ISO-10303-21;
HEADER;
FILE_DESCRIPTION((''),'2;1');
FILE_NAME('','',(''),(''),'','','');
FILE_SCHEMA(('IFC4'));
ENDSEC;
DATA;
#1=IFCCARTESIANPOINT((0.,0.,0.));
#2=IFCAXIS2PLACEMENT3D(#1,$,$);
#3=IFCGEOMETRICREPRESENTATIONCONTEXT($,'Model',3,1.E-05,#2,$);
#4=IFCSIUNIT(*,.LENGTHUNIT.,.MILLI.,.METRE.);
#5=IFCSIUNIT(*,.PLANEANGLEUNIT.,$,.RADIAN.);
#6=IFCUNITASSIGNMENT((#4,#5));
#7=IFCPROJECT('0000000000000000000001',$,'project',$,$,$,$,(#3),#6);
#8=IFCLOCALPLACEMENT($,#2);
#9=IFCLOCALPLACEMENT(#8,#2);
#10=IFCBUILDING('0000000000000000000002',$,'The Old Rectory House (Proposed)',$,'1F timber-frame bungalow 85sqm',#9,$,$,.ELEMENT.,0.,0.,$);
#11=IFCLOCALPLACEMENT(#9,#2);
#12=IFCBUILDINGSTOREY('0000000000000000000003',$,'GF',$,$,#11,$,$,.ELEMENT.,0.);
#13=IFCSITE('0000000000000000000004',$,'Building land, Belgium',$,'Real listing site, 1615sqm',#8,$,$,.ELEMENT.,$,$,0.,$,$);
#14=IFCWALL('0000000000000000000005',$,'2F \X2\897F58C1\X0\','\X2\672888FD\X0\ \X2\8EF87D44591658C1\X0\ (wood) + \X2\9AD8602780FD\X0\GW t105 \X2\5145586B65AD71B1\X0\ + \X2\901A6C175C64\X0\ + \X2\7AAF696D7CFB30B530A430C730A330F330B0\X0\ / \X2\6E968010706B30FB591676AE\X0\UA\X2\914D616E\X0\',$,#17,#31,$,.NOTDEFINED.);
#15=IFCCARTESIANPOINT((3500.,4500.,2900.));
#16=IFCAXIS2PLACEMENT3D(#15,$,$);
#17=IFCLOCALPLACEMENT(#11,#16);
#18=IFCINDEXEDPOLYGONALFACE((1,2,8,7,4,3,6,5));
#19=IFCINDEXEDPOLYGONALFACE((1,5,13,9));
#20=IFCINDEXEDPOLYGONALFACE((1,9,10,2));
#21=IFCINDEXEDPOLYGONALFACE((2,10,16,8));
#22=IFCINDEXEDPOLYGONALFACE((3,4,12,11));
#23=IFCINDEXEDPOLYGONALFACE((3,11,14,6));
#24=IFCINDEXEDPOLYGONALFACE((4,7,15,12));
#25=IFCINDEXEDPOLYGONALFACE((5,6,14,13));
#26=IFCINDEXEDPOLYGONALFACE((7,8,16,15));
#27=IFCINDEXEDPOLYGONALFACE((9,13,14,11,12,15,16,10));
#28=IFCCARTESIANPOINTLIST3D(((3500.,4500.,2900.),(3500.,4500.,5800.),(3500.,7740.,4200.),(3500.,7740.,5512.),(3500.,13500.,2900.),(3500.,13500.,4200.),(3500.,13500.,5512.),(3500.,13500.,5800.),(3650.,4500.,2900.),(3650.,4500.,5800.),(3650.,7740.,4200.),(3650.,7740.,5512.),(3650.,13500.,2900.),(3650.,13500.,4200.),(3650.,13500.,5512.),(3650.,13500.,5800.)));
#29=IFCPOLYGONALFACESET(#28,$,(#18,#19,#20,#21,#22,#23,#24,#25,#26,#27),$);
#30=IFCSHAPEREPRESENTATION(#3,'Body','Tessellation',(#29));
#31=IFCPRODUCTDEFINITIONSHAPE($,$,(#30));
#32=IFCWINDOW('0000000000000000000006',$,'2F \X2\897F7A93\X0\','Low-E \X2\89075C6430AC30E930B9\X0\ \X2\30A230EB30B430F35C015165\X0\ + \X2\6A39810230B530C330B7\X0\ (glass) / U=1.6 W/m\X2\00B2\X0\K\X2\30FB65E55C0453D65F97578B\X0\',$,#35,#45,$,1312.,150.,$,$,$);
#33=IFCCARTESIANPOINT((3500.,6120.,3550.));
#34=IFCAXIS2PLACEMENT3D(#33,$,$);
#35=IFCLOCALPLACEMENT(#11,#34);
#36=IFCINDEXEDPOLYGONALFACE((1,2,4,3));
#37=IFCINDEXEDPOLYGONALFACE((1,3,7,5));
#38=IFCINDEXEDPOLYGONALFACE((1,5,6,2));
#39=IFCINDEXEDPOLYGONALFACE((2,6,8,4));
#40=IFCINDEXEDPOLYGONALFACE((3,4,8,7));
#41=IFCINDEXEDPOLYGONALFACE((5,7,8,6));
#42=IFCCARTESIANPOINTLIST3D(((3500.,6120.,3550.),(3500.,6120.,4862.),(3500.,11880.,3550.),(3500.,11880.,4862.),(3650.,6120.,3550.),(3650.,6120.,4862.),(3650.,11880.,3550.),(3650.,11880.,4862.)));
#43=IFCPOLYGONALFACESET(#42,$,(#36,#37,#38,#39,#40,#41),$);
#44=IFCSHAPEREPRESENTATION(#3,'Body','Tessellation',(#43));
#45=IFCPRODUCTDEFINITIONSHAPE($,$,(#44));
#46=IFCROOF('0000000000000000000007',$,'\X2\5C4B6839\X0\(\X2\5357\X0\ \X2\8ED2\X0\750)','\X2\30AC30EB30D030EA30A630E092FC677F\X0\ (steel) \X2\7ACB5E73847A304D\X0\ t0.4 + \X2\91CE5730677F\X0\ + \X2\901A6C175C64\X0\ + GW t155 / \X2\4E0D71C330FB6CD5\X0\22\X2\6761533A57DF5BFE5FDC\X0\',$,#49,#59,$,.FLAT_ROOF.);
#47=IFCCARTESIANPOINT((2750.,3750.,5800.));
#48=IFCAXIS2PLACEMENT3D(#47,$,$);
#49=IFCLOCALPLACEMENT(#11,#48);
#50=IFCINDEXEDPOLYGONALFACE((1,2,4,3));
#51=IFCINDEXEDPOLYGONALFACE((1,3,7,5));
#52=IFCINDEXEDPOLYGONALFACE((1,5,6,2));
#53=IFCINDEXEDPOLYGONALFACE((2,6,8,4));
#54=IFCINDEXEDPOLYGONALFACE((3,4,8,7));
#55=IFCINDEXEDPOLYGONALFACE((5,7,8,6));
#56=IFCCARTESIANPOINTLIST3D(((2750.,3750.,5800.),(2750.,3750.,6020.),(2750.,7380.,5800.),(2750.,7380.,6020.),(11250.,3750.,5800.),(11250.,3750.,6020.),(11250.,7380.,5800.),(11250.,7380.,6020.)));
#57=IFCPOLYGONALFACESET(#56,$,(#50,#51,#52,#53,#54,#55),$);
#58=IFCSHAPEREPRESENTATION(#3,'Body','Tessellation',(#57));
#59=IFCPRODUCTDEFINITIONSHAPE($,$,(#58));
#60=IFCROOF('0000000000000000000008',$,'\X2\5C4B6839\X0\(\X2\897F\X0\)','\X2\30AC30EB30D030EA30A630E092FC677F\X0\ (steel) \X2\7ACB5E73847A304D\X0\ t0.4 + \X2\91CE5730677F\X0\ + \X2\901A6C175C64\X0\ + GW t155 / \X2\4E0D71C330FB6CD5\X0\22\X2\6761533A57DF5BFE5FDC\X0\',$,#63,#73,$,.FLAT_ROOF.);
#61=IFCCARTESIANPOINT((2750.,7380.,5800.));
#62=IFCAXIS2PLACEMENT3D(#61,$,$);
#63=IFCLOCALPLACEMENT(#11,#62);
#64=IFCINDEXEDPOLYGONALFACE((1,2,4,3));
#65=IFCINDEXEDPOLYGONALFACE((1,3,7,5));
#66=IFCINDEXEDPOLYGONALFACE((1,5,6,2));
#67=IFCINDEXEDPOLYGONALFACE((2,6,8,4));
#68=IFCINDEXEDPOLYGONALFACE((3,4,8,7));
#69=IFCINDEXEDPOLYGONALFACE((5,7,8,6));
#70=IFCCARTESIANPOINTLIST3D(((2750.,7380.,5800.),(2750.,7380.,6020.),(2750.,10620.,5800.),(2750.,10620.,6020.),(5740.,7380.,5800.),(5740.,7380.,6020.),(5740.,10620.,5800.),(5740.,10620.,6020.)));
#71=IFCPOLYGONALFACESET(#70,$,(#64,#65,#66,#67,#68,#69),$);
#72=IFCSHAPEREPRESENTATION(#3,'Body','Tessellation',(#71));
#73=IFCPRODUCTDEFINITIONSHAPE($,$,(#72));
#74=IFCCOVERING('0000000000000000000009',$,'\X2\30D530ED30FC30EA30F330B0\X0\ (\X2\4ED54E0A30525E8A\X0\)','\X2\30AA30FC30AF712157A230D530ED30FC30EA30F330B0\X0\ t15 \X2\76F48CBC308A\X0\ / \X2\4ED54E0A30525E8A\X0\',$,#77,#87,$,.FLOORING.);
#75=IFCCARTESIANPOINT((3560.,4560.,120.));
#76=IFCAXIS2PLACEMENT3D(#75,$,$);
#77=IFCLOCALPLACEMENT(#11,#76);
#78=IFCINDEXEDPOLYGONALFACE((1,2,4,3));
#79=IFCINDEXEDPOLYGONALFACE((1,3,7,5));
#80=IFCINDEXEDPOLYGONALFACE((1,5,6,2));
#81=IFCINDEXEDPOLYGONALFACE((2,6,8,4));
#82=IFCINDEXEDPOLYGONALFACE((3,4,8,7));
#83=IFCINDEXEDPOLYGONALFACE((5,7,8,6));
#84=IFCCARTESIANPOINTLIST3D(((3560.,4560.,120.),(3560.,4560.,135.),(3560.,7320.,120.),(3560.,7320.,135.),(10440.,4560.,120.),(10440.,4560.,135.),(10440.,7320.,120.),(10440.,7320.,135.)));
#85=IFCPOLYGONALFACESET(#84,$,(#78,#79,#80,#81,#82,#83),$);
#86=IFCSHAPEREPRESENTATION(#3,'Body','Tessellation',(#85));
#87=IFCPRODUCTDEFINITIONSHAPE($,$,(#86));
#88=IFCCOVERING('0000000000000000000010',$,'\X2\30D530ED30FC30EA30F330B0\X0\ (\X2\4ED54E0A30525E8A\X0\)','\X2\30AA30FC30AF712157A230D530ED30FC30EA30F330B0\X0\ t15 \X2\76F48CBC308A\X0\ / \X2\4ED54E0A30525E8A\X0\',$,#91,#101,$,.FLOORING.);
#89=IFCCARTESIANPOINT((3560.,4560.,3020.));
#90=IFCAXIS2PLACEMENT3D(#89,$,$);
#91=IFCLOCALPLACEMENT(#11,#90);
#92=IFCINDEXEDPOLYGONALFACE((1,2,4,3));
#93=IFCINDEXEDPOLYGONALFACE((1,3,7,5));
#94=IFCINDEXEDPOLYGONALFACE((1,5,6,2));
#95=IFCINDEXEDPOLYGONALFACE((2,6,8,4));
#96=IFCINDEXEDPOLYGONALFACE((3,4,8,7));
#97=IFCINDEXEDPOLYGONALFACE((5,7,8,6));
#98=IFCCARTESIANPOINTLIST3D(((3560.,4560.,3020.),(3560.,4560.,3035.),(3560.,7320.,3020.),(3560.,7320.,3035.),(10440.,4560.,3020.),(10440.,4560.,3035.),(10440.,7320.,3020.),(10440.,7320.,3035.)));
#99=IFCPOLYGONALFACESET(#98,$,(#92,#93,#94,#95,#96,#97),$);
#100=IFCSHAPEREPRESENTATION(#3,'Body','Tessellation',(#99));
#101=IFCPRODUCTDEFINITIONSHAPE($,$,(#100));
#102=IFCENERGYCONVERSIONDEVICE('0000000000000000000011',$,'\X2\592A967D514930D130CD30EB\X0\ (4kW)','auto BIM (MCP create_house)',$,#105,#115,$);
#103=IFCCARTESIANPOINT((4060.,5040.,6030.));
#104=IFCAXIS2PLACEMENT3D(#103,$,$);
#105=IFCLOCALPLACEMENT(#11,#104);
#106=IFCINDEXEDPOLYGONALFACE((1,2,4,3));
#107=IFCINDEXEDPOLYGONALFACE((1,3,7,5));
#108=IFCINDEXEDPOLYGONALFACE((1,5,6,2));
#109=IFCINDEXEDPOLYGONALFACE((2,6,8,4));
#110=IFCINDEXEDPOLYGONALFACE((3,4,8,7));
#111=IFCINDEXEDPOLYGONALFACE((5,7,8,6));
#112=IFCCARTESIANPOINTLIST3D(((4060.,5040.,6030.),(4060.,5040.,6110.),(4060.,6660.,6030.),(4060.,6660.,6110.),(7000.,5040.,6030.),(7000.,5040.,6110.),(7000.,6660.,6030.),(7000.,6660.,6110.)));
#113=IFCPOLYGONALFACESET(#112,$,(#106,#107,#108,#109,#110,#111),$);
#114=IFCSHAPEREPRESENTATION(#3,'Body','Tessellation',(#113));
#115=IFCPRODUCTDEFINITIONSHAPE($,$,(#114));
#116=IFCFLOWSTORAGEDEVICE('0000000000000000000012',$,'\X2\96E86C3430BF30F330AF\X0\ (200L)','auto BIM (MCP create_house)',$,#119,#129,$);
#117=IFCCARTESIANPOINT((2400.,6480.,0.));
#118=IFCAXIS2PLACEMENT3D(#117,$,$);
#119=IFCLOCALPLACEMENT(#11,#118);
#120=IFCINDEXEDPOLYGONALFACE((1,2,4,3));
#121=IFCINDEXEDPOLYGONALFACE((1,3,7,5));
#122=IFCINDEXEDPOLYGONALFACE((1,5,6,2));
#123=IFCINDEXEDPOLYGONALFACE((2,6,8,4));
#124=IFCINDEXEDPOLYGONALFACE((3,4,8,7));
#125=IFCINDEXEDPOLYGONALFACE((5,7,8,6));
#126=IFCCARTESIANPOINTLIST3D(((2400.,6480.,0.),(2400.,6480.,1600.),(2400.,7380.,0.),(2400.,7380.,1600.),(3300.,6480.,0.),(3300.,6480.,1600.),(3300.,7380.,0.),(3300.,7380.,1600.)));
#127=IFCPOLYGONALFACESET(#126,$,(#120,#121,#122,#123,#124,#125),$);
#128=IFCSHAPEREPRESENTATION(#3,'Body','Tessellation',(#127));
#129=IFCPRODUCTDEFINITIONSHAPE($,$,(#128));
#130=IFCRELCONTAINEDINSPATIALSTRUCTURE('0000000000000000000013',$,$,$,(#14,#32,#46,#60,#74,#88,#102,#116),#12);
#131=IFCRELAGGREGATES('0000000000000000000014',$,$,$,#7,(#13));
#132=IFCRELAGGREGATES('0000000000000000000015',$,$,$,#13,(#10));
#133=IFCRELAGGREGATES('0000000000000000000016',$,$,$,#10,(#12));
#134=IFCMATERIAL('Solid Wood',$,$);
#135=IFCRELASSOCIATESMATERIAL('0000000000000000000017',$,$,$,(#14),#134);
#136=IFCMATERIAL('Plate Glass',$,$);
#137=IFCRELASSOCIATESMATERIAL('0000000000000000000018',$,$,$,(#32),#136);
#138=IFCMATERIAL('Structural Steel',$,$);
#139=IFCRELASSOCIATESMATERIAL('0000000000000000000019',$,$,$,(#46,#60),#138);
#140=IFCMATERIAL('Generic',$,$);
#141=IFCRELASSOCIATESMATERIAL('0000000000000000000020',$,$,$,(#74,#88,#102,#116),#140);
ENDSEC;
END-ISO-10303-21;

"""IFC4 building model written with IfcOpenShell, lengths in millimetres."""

from ifc_helpers import new_model, si_unit, frame, frame_2d, origin, place, context, project, spatial, rectangle, extrude, material, element, fill, save


model = new_model("IFC4")

# Units and contexts
model_context = context("Model", 3, precision=1e-05, world=origin())
ifc_project = project(units=[si_unit("LENGTHUNIT", "METRE", prefix="MILLI"), si_unit("PLANEANGLEUNIT", "RADIAN")], contexts=[model_context])

# Site, building, storey
site_placement = place(None, origin())
site = spatial("IfcSite", under=ifc_project, at=site_placement, Name="Building land, Belgium", ObjectType="Real listing site, 1615sqm", CompositionType="ELEMENT", RefElevation=0.0)
building_placement = place(site_placement, origin())
building = spatial("IfcBuilding", under=site, at=building_placement, Name="The Old Rectory House (Proposed)", ObjectType="1F timber-frame bungalow 85sqm", CompositionType="ELEMENT", ElevationOfRefHeight=0.0, ElevationOfTerrain=0.0)
storey_placement = place(building_placement, origin())
storey = spatial("IfcBuildingStorey", under=building, at=storey_placement, Name="GF", CompositionType="ELEMENT", Elevation=0.0)

# Shared definitions
ifc_material_1 = material(Name="Solid Wood")
ifc_material_2 = material(Name="Generic")

# Shared definitions
ifc_material_3 = material(Name="Plate Glass")

# Wall, opening, window
wall_1_placement = place(storey_placement, frame((3500.0, 4500.0, 2900.0)))
wall_1 = element("IfcWall", 1, at=wall_1_placement, inside=storey, material=ifc_material_1, Name="2F 西壁", Description="木製 軸組外壁 (wood) + 高性能GW t105 充填断熱 + 通気層 + 窯業系サイディング / 準耐火・外皮UA配慮", PredefinedType="NOTDEFINED", context=model_context, shape_type="SweptSolid", body=[
    extrude(rectangle(XDim=150.0, YDim=9000.0, at=frame_2d((75.0, 4500.0))), frame((3500.0, 4500.0, 2900.0)), (0.0, 0.0, 1.0), 2900.0),
])
opening_1_placement = place(storey_placement, frame((3500.0, 6120.0, 3550.0)))
opening_1 = element("IfcOpeningElement", 2, at=opening_1_placement, cuts=wall_1, PredefinedType="NOTDEFINED", context=model_context, shape_type="SweptSolid", body=[
    extrude(rectangle(XDim=150.0, YDim=5760.0, at=frame_2d((75.0, 2880.0))), frame((3500.0, 6120.0, 3550.0)), (0.0, 0.0, 1.0), 1312.0),
])
window_1_placement = place(storey_placement, frame((3500.0, 6120.0, 3550.0)))
window_1 = element("IfcWindow", 3, at=window_1_placement, inside=storey, material=ifc_material_3, Name="2F 西窓", Description="Low-E 複層ガラス アルゴン封入 + 樹脂サッシ (glass) / U=1.6 W/m²K・日射取得型", OverallHeight=1312.0, OverallWidth=150.0, context=model_context, shape_type="SweptSolid", body=[
    extrude(rectangle(XDim=150.0, YDim=5760.0, at=frame_2d((75.0, 2880.0))), frame((3500.0, 6120.0, 3550.0)), (0.0, 0.0, 1.0), 1312.0),
])
fill(opening_1, window_1)

# Roofs
ifc_material_4 = material(Name="Structural Steel")
roof_1_placement = place(storey_placement, frame((2750.0, 3750.0, 5800.0)))
element("IfcRoof", 4, at=roof_1_placement, inside=storey, material=ifc_material_4, Name="屋根(南 軒750)", Description="ガルバリウム鋼板 (steel) 立平葺き t0.4 + 野地板 + 通気層 + GW t155 / 不燃・法22条区域対応", PredefinedType="FLAT_ROOF", context=model_context, shape_type="SweptSolid", body=[
    extrude(rectangle(XDim=8500.0, YDim=3630.0, at=frame_2d((4250.0, 1815.0))), frame((2750.0, 3750.0, 5800.0)), (0.0, 0.0, 1.0), 220.0),
])
roof_2_placement = place(storey_placement, frame((2750.0, 7380.0, 5800.0)))
element("IfcRoof", 5, at=roof_2_placement, inside=storey, material=ifc_material_4, Name="屋根(西)", Description="ガルバリウム鋼板 (steel) 立平葺き t0.4 + 野地板 + 通気層 + GW t155 / 不燃・法22条区域対応", PredefinedType="FLAT_ROOF", context=model_context, shape_type="SweptSolid", body=[
    extrude(rectangle(XDim=2990.0, YDim=3240.0, at=frame_2d((1495.0, 1620.0))), frame((2750.0, 7380.0, 5800.0)), (0.0, 0.0, 1.0), 220.0),
])

# Coverings
covering_1_placement = place(storey_placement, frame((3560.0, 4560.0, 120.0)))
element("IfcCovering", 6, at=covering_1_placement, inside=storey, material=ifc_material_2, Name="フローリング (仕上げ床)", Description="オーク無垢フローリング t15 直貼り / 仕上げ床", PredefinedType="FLOORING", context=model_context, shape_type="SweptSolid", body=[
    extrude(rectangle(XDim=6880.0, YDim=2760.0, at=frame_2d((3440.0, 1380.0))), frame((3560.0, 4560.0, 120.0)), (0.0, 0.0, 1.0), 15.0),
])
covering_2_placement = place(storey_placement, frame((3560.0, 4560.0, 3020.0)))
element("IfcCovering", 7, at=covering_2_placement, inside=storey, material=ifc_material_2, Name="フローリング (仕上げ床)", Description="オーク無垢フローリング t15 直貼り / 仕上げ床", PredefinedType="FLOORING", context=model_context, shape_type="SweptSolid", body=[
    extrude(rectangle(XDim=6880.0, YDim=2760.0, at=frame_2d((3440.0, 1380.0))), frame((3560.0, 4560.0, 3020.0)), (0.0, 0.0, 1.0), 15.0),
])

# Energy conversion device
energy_conversion_device_placement = place(storey_placement, frame((4060.0, 5040.0, 6030.0)))
element("IfcEnergyConversionDevice", 8, at=energy_conversion_device_placement, inside=storey, material=ifc_material_2, Name="太陽光パネル (4kW)", Description="auto BIM (MCP create_house)", context=model_context, shape_type="SweptSolid", body=[
    extrude(rectangle(XDim=2940.0, YDim=1620.0, at=frame_2d((1470.0, 810.0))), frame((4060.0, 5040.0, 6030.0)), (0.0, 0.0, 1.0), 80.0),
])

# Flow storage device
flow_storage_device_placement = place(storey_placement, frame((2400.0, 6480.0, 0.0)))
element("IfcFlowStorageDevice", 9, at=flow_storage_device_placement, inside=storey, material=ifc_material_2, Name="雨水タンク (200L)", Description="auto BIM (MCP create_house)", context=model_context, shape_type="SweptSolid", body=[
    extrude(rectangle(XDim=900.0, YDim=900.0, at=frame_2d((450.0, 450.0))), frame((2400.0, 6480.0, 0.0)), (0.0, 0.0, 1.0), 1600.0),
])

save(model, "model.ifc")
